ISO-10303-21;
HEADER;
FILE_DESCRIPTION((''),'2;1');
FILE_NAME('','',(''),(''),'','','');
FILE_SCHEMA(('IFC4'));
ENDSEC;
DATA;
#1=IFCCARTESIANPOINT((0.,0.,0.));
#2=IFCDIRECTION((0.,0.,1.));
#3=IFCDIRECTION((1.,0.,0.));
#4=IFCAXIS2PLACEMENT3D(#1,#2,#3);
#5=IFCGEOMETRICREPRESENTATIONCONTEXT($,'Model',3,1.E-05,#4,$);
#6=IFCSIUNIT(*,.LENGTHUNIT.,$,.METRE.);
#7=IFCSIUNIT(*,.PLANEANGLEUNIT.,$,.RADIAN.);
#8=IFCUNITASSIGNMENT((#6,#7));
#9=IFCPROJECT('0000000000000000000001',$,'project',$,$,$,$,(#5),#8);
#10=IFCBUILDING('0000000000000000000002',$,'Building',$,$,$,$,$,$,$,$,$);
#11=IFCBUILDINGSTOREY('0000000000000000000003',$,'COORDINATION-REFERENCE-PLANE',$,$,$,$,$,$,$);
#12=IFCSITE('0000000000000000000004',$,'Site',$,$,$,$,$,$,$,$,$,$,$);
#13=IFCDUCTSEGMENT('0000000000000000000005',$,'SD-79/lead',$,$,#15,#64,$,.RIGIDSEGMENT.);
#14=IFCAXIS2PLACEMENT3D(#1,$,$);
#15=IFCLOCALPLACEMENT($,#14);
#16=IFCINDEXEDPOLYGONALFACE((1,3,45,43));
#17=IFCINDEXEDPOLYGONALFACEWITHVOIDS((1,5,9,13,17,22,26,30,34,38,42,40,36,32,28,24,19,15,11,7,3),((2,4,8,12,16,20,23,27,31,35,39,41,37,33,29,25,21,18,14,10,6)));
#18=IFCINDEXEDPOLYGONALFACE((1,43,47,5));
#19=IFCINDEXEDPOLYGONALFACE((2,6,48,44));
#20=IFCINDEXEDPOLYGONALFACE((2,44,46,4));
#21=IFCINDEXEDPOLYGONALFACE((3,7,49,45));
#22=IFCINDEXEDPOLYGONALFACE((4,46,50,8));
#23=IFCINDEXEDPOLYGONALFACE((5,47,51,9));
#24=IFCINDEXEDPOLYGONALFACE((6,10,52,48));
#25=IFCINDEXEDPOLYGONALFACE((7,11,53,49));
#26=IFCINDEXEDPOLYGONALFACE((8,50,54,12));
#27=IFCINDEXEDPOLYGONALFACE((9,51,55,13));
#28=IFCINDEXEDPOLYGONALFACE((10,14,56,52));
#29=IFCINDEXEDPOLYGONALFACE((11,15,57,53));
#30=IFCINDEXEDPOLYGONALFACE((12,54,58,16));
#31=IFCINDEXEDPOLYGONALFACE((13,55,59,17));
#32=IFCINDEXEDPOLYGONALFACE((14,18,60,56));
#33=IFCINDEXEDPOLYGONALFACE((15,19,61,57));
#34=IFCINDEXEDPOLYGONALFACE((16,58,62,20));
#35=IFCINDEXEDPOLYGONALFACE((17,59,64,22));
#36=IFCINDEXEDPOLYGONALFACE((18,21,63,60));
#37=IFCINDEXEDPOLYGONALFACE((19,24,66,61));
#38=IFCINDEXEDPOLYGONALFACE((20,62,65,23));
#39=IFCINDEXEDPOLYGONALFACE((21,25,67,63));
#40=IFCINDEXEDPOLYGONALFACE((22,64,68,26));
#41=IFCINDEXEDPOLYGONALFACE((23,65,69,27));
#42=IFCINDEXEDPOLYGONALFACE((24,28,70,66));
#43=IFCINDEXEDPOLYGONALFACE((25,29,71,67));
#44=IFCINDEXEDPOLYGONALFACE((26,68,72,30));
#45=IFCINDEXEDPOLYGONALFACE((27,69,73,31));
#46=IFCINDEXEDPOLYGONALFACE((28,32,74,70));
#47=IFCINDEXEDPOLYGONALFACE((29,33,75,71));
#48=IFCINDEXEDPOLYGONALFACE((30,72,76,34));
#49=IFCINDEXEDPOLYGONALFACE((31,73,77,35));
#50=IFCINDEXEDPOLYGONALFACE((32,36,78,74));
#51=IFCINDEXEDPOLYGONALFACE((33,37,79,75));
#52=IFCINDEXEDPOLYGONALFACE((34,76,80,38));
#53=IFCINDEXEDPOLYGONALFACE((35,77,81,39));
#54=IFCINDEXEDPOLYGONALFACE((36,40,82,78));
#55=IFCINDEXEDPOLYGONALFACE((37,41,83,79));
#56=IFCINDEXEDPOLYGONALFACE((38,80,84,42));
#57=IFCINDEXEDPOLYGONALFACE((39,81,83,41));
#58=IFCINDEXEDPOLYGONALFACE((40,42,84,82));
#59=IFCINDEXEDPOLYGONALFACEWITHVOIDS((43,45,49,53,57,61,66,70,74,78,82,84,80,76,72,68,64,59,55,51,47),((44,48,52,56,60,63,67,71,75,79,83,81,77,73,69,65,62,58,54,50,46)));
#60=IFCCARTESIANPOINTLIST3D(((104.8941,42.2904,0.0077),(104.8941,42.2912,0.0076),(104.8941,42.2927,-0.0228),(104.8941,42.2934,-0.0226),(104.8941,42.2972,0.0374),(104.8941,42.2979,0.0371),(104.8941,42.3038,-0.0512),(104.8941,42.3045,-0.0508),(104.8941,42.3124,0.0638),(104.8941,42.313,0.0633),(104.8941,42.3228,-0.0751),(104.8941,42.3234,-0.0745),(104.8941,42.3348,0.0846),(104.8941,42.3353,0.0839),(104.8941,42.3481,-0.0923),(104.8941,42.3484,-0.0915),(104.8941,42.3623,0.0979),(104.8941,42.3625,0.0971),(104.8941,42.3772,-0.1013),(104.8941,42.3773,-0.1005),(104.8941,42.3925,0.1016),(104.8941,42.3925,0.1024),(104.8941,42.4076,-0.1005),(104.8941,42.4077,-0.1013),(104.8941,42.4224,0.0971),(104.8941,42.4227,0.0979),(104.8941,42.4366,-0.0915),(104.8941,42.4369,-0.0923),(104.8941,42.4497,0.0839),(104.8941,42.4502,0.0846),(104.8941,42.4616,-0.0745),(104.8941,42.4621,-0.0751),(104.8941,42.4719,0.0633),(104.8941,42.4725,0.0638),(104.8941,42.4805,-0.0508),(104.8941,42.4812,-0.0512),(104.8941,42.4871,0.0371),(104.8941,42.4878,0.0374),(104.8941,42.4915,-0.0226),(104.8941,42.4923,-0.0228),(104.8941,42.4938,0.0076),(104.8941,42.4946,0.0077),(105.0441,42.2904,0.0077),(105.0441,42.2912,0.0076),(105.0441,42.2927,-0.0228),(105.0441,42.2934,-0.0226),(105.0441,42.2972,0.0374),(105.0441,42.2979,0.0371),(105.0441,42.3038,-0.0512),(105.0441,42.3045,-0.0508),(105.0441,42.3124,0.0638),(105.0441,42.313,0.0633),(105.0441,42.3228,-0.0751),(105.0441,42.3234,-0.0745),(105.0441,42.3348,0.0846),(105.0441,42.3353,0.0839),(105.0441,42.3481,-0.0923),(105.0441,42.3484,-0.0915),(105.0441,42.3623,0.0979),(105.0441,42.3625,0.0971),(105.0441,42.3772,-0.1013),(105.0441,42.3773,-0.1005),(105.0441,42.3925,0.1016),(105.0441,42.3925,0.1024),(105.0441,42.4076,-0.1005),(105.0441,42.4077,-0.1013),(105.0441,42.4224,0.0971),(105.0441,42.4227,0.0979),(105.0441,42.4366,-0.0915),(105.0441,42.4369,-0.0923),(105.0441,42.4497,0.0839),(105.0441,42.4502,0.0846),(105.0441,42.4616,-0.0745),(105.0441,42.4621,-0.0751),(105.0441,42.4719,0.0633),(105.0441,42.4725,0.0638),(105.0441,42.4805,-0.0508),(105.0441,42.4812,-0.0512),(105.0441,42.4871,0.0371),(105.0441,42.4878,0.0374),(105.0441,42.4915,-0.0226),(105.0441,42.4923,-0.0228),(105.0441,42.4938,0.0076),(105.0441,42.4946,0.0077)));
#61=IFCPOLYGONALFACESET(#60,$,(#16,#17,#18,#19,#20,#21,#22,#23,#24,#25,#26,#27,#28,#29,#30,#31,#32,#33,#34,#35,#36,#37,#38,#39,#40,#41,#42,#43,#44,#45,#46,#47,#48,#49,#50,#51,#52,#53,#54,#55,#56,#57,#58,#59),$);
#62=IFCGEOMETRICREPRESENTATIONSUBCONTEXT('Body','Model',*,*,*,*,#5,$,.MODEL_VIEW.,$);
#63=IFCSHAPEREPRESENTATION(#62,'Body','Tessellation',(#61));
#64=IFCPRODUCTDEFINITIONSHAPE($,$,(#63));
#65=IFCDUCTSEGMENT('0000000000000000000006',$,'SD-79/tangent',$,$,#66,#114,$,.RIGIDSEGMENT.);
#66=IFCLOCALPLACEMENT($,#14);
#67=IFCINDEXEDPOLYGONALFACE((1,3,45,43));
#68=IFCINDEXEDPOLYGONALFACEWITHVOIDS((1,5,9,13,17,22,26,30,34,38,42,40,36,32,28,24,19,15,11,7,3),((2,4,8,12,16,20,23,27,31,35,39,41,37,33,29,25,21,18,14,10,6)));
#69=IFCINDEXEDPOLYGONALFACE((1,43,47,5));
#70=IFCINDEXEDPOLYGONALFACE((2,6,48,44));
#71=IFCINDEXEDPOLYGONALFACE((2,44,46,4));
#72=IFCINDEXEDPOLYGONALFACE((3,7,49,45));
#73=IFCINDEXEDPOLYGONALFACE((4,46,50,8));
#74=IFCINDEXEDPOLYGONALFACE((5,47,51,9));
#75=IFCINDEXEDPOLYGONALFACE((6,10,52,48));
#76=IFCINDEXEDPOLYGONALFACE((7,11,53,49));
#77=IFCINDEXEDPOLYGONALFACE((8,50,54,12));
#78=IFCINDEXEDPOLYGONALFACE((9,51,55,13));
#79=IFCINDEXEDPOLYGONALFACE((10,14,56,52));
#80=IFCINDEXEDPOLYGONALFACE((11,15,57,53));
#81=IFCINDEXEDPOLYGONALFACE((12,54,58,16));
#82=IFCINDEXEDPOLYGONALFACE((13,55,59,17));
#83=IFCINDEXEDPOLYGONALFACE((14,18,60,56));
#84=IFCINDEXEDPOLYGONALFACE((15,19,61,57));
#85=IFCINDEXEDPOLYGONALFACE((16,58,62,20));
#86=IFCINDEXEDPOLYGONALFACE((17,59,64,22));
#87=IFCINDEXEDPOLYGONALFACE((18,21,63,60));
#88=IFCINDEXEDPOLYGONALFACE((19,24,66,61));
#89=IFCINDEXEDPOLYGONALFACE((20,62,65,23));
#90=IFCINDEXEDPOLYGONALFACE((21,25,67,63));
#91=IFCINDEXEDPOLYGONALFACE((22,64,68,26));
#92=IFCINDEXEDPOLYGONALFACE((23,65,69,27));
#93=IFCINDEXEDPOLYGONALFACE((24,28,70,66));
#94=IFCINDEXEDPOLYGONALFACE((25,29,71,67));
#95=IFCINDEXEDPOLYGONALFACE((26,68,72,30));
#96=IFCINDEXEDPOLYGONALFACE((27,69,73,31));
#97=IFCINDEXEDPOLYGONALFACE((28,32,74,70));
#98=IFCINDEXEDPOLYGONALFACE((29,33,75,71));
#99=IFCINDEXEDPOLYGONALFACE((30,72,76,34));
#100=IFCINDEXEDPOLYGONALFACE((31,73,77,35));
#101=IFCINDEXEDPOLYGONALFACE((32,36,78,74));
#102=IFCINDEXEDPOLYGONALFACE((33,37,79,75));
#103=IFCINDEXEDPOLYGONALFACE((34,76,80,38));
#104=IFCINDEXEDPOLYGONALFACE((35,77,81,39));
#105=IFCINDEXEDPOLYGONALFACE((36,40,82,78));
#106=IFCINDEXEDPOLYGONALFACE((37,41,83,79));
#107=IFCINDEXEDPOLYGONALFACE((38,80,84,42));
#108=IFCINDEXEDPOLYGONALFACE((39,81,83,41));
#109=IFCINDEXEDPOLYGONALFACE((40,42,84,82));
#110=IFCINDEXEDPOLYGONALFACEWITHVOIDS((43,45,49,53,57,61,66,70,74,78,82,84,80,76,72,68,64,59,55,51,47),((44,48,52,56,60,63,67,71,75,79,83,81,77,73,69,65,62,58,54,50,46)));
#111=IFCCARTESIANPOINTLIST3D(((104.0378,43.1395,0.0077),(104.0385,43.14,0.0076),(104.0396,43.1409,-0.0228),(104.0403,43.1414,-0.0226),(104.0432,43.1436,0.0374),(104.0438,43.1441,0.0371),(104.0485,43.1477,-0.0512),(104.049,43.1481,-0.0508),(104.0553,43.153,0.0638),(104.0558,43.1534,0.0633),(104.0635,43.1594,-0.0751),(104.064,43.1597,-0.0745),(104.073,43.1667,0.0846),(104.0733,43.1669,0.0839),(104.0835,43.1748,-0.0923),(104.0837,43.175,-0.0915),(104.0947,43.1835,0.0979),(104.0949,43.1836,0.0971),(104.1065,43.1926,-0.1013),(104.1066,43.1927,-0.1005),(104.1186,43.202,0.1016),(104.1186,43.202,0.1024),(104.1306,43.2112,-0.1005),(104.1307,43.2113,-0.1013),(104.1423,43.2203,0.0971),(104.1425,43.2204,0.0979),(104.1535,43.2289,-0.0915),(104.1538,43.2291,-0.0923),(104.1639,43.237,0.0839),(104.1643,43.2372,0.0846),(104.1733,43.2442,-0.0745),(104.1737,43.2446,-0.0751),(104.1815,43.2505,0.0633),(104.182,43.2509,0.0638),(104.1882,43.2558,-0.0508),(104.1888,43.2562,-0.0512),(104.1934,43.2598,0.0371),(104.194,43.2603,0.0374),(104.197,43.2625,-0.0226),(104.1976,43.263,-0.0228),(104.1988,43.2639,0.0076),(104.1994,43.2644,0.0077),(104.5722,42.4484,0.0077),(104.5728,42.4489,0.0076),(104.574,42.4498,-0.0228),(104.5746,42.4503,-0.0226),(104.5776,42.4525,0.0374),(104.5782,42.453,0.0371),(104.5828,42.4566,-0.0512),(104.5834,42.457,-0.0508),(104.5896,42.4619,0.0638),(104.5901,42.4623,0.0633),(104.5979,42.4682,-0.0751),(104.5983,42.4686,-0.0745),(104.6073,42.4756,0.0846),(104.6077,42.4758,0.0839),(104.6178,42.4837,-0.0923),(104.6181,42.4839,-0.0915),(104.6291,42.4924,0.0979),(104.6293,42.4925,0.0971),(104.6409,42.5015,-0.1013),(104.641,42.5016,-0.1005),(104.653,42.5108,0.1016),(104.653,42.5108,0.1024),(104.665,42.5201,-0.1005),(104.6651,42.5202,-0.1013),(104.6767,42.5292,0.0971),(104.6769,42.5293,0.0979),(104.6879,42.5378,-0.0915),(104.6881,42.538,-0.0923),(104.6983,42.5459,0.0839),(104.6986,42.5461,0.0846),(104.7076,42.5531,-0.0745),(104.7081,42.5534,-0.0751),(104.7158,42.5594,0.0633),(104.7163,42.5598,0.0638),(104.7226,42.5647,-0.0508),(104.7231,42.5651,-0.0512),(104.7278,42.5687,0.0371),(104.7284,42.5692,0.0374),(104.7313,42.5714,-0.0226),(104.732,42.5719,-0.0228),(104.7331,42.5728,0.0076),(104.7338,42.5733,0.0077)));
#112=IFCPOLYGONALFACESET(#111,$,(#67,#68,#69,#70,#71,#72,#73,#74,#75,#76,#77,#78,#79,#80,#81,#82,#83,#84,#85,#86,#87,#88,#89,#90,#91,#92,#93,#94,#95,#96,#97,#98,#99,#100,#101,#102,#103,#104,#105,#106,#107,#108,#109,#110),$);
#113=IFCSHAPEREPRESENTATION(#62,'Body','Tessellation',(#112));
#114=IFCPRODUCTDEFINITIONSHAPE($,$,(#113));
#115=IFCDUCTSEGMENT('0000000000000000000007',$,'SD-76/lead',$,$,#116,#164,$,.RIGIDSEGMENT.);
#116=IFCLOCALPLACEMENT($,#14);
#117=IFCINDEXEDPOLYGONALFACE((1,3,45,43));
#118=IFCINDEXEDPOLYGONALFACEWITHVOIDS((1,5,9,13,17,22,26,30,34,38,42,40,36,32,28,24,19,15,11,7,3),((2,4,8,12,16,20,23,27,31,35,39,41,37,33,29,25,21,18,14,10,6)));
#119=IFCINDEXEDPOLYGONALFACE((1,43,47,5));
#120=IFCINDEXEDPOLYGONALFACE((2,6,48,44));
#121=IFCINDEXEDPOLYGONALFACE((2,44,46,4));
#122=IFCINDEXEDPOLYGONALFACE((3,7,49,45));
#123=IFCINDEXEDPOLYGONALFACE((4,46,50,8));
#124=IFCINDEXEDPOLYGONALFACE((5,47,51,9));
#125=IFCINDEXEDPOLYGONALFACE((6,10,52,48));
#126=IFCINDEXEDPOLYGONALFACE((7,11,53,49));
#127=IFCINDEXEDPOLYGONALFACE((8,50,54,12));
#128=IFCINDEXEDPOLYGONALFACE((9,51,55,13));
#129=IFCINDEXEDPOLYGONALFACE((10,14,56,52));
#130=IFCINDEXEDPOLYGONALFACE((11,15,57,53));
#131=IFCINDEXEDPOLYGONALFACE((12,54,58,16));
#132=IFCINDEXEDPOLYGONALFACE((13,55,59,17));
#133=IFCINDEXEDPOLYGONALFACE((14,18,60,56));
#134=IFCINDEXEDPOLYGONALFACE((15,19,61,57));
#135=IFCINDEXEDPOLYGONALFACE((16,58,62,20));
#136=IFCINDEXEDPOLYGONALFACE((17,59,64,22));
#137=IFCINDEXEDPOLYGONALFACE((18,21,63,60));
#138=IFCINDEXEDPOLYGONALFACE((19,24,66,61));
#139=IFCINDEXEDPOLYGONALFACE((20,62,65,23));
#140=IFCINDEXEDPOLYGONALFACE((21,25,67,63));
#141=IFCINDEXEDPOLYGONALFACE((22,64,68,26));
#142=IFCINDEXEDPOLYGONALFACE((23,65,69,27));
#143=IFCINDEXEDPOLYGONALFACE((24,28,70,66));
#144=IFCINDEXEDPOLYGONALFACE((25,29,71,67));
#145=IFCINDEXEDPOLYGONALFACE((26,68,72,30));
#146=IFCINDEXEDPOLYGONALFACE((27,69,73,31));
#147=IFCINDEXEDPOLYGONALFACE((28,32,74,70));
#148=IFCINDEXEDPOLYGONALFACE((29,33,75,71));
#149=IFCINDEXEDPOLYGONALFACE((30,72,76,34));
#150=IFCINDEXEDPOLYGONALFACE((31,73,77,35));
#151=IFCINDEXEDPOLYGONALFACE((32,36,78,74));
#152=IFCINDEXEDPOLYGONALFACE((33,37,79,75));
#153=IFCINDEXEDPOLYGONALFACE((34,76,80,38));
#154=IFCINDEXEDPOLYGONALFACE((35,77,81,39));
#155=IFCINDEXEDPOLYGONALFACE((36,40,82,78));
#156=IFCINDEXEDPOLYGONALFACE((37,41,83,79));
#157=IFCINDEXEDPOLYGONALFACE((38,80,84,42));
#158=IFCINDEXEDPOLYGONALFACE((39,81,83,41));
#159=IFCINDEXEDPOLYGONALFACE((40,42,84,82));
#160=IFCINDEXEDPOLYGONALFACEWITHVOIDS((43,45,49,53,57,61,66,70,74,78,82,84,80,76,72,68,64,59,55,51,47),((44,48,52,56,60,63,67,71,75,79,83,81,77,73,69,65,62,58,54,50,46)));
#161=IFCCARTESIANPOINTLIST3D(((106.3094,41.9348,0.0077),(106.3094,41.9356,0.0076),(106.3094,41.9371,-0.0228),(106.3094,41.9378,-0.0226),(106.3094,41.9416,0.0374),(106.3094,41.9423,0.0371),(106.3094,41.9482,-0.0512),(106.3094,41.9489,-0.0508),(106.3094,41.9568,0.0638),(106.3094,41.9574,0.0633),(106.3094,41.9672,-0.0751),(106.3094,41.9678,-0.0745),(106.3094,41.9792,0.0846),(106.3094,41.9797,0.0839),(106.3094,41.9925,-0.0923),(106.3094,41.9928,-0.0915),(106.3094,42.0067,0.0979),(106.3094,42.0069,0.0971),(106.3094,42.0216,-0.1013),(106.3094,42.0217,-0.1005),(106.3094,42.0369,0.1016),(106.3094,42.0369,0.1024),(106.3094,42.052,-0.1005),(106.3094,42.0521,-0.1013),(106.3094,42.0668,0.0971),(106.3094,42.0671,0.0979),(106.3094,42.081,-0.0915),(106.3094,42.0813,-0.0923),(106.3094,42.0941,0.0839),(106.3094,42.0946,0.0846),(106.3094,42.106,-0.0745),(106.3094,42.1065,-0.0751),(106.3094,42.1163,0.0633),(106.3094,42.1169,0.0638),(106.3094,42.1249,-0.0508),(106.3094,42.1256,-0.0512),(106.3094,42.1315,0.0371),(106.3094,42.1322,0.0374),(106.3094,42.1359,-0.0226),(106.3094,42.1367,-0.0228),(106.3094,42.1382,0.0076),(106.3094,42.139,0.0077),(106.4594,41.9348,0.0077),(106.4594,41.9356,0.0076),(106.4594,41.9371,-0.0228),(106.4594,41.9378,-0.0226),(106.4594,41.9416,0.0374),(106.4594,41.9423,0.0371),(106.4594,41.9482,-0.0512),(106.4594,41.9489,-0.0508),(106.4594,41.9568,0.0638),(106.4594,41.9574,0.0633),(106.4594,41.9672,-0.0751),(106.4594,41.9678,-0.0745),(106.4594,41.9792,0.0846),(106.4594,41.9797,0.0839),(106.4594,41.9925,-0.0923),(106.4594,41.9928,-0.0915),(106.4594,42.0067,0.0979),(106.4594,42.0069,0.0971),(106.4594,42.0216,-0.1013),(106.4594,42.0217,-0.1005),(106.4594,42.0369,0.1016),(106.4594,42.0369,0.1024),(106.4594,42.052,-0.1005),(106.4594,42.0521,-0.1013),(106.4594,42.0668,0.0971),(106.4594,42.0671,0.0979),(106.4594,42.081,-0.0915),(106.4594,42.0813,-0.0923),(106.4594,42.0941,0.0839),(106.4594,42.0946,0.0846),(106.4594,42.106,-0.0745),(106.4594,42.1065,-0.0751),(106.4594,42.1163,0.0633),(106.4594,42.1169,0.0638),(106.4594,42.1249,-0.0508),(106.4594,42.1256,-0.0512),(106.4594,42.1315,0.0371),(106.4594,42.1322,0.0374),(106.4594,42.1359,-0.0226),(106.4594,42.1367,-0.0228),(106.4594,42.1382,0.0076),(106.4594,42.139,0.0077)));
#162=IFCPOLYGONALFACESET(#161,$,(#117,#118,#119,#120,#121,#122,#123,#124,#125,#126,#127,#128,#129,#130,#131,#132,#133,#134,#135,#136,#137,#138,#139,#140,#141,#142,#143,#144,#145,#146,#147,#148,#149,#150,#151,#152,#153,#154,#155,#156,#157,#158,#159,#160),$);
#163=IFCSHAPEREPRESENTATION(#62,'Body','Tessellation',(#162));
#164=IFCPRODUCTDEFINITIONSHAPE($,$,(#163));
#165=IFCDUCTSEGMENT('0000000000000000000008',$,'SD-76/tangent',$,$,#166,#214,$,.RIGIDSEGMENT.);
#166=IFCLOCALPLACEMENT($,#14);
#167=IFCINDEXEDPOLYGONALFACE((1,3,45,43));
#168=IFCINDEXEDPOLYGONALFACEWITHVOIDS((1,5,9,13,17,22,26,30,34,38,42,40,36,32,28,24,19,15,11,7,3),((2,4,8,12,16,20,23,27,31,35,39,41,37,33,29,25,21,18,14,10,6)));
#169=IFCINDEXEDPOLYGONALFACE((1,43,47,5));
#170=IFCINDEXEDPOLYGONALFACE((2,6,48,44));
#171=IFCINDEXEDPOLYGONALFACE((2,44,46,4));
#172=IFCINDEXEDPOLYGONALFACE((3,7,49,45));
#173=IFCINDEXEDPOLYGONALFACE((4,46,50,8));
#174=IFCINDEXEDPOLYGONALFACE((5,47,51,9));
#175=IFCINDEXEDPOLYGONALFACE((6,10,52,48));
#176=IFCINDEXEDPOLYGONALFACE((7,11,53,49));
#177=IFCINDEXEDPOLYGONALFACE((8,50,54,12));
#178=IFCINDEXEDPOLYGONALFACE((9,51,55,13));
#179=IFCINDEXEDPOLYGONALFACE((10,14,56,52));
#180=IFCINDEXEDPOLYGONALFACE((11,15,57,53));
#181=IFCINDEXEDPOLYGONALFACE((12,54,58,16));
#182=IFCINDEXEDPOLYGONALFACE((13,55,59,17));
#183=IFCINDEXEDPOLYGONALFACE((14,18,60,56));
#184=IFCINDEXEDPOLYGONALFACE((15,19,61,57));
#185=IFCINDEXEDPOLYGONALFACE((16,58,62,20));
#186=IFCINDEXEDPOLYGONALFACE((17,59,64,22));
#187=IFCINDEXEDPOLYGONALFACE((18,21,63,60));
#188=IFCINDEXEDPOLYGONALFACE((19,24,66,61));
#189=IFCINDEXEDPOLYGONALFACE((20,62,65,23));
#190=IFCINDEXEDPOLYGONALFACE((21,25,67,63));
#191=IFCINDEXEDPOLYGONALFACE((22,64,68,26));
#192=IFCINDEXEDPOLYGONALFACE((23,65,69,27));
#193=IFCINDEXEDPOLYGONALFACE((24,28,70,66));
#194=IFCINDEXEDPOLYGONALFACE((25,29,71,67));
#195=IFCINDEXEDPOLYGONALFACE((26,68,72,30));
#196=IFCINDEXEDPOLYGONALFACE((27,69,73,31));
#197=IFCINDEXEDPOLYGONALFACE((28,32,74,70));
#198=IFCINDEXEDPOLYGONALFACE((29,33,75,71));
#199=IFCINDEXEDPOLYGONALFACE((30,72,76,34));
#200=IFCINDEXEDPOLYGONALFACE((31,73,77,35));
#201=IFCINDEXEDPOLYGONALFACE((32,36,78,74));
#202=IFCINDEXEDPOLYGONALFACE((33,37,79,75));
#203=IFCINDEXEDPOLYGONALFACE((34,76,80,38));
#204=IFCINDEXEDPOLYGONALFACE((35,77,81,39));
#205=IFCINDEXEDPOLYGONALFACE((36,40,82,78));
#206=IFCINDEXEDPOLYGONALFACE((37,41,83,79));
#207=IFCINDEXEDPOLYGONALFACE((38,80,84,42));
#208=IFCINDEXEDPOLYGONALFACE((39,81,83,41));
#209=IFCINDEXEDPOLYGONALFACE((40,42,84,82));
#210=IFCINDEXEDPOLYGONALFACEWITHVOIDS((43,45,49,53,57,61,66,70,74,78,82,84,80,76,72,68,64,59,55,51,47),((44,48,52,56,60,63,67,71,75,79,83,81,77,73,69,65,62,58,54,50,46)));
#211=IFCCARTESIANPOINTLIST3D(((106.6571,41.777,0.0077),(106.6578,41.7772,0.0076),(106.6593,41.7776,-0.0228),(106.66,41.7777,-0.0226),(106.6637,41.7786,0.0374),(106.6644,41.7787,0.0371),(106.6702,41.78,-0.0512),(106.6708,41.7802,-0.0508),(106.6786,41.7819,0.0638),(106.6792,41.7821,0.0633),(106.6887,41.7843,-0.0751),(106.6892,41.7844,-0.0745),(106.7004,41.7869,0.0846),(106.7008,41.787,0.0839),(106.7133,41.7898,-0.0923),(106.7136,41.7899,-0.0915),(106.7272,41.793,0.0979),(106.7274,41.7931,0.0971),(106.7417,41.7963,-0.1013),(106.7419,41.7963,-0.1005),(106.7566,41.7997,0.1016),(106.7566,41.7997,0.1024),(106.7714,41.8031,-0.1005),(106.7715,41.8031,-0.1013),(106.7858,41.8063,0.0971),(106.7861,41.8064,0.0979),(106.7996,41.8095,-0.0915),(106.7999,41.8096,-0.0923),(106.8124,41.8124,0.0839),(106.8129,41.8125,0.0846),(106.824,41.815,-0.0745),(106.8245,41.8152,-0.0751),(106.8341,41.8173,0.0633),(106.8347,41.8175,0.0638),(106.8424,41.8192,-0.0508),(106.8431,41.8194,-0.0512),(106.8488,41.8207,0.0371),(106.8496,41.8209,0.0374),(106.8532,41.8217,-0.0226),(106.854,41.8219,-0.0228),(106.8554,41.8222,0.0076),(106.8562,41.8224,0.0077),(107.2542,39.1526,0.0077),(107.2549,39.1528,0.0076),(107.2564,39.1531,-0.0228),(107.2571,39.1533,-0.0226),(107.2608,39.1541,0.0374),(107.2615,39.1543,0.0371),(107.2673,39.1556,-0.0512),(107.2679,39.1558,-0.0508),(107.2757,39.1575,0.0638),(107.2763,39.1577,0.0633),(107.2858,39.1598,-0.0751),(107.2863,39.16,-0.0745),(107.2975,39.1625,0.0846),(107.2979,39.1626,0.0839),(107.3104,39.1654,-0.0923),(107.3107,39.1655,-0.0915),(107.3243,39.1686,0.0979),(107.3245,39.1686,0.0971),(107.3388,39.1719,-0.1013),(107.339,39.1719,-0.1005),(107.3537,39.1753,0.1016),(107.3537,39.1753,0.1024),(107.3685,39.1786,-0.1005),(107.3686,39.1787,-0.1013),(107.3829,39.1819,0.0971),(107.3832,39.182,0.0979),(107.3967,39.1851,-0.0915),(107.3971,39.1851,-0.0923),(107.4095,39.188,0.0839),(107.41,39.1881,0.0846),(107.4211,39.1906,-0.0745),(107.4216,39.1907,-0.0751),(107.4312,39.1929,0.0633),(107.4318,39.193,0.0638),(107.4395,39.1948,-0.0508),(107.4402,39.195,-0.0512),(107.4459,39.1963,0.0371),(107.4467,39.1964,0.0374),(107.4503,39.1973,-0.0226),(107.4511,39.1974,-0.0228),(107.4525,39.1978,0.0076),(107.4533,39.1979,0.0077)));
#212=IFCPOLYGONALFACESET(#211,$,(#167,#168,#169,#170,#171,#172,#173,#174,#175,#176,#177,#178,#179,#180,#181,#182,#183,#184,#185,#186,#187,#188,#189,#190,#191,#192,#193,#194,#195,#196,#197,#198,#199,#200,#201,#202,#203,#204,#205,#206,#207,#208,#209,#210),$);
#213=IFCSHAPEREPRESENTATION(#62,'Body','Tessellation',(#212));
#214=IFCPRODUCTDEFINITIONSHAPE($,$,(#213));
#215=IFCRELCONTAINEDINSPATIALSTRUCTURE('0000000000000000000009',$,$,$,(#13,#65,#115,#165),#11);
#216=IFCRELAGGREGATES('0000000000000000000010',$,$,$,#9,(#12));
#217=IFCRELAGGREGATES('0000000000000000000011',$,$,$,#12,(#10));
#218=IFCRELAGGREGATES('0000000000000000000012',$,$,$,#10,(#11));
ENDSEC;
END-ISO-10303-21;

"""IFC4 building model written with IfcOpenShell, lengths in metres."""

from ifc_helpers import new_model, si_unit, frame, origin_with_axes, place, context, subcontext, project, spatial, hollow_circle, extrude, element, save


model = new_model("IFC4")

# Units and contexts
model_context_1 = context("Model", 3, precision=1e-05, world=origin_with_axes())
body_context_1 = subcontext(model_context_1, "Body", "Model", "MODEL_VIEW")
ifc_project = project(units=[si_unit("LENGTHUNIT", "METRE"), si_unit("PLANEANGLEUNIT", "RADIAN")], contexts=[model_context_1])

# Site, building, storey
site = spatial("IfcSite", under=ifc_project, Name="Site")
building = spatial("IfcBuilding", under=site, Name="Building")
storey = spatial("IfcBuildingStorey", under=building, Name="COORDINATION-REFERENCE-PLANE")

# Duct segment
duct_segment_1_placement = place(None, frame((105.0441, 42.3925, 0.0), z_axis=(-1.0, 0.0, 0.0), x_axis=(0.0, 0.0, 1.0)))
element("IfcDuctSegment", 1, at=duct_segment_1_placement, inside=storey, Name="SD-79/lead", PredefinedType="RIGIDSEGMENT", context=body_context_1, shape_type="SweptSolid", body=[
    extrude(hollow_circle(Radius=0.1024, WallThickness=0.0008), origin_with_axes(), (0.0, 0.0, 1.0), 0.15),
])

# Duct segment
duct_segment_2_placement = place(None, frame((104.653, 42.5108, 0.0), z_axis=(-0.611676, 0.791108, 0.0), x_axis=(0.0, 0.0, 1.0)))
element("IfcDuctSegment", 2, at=duct_segment_2_placement, inside=storey, Name="SD-79/tangent", PredefinedType="RIGIDSEGMENT", context=body_context_1, shape_type="SweptSolid", body=[
    extrude(hollow_circle(Radius=0.1024, WallThickness=0.0008), origin_with_axes(), (0.0, 0.0, 1.0), 0.8736),
])

# Duct segment
duct_segment_3_placement = place(None, frame((106.3094, 42.0369, 0.0), z_axis=(1.0, 0.0, 0.0), x_axis=(0.0, 0.0, 1.0)))
element("IfcDuctSegment", 3, at=duct_segment_3_placement, inside=storey, Name="SD-76/lead", PredefinedType="RIGIDSEGMENT", context=body_context_1, shape_type="SweptSolid", body=[
    extrude(hollow_circle(Radius=0.1024, WallThickness=0.0008), origin_with_axes(), (0.0, 0.0, 1.0), 0.15),
])

# Duct segment
duct_segment_4_placement = place(None, frame((106.7566, 41.7997, 0.0), z_axis=(0.221849, -0.975081, 0.0), x_axis=(0.0, 0.0, 1.0)))
element("IfcDuctSegment", 4, at=duct_segment_4_placement, inside=storey, Name="SD-76/tangent", PredefinedType="RIGIDSEGMENT", context=body_context_1, shape_type="SweptSolid", body=[
    extrude(hollow_circle(Radius=0.1024, WallThickness=0.0008), origin_with_axes(), (0.0, 0.0, 1.0), 2.6915),
])

save(model, "model.ifc")
